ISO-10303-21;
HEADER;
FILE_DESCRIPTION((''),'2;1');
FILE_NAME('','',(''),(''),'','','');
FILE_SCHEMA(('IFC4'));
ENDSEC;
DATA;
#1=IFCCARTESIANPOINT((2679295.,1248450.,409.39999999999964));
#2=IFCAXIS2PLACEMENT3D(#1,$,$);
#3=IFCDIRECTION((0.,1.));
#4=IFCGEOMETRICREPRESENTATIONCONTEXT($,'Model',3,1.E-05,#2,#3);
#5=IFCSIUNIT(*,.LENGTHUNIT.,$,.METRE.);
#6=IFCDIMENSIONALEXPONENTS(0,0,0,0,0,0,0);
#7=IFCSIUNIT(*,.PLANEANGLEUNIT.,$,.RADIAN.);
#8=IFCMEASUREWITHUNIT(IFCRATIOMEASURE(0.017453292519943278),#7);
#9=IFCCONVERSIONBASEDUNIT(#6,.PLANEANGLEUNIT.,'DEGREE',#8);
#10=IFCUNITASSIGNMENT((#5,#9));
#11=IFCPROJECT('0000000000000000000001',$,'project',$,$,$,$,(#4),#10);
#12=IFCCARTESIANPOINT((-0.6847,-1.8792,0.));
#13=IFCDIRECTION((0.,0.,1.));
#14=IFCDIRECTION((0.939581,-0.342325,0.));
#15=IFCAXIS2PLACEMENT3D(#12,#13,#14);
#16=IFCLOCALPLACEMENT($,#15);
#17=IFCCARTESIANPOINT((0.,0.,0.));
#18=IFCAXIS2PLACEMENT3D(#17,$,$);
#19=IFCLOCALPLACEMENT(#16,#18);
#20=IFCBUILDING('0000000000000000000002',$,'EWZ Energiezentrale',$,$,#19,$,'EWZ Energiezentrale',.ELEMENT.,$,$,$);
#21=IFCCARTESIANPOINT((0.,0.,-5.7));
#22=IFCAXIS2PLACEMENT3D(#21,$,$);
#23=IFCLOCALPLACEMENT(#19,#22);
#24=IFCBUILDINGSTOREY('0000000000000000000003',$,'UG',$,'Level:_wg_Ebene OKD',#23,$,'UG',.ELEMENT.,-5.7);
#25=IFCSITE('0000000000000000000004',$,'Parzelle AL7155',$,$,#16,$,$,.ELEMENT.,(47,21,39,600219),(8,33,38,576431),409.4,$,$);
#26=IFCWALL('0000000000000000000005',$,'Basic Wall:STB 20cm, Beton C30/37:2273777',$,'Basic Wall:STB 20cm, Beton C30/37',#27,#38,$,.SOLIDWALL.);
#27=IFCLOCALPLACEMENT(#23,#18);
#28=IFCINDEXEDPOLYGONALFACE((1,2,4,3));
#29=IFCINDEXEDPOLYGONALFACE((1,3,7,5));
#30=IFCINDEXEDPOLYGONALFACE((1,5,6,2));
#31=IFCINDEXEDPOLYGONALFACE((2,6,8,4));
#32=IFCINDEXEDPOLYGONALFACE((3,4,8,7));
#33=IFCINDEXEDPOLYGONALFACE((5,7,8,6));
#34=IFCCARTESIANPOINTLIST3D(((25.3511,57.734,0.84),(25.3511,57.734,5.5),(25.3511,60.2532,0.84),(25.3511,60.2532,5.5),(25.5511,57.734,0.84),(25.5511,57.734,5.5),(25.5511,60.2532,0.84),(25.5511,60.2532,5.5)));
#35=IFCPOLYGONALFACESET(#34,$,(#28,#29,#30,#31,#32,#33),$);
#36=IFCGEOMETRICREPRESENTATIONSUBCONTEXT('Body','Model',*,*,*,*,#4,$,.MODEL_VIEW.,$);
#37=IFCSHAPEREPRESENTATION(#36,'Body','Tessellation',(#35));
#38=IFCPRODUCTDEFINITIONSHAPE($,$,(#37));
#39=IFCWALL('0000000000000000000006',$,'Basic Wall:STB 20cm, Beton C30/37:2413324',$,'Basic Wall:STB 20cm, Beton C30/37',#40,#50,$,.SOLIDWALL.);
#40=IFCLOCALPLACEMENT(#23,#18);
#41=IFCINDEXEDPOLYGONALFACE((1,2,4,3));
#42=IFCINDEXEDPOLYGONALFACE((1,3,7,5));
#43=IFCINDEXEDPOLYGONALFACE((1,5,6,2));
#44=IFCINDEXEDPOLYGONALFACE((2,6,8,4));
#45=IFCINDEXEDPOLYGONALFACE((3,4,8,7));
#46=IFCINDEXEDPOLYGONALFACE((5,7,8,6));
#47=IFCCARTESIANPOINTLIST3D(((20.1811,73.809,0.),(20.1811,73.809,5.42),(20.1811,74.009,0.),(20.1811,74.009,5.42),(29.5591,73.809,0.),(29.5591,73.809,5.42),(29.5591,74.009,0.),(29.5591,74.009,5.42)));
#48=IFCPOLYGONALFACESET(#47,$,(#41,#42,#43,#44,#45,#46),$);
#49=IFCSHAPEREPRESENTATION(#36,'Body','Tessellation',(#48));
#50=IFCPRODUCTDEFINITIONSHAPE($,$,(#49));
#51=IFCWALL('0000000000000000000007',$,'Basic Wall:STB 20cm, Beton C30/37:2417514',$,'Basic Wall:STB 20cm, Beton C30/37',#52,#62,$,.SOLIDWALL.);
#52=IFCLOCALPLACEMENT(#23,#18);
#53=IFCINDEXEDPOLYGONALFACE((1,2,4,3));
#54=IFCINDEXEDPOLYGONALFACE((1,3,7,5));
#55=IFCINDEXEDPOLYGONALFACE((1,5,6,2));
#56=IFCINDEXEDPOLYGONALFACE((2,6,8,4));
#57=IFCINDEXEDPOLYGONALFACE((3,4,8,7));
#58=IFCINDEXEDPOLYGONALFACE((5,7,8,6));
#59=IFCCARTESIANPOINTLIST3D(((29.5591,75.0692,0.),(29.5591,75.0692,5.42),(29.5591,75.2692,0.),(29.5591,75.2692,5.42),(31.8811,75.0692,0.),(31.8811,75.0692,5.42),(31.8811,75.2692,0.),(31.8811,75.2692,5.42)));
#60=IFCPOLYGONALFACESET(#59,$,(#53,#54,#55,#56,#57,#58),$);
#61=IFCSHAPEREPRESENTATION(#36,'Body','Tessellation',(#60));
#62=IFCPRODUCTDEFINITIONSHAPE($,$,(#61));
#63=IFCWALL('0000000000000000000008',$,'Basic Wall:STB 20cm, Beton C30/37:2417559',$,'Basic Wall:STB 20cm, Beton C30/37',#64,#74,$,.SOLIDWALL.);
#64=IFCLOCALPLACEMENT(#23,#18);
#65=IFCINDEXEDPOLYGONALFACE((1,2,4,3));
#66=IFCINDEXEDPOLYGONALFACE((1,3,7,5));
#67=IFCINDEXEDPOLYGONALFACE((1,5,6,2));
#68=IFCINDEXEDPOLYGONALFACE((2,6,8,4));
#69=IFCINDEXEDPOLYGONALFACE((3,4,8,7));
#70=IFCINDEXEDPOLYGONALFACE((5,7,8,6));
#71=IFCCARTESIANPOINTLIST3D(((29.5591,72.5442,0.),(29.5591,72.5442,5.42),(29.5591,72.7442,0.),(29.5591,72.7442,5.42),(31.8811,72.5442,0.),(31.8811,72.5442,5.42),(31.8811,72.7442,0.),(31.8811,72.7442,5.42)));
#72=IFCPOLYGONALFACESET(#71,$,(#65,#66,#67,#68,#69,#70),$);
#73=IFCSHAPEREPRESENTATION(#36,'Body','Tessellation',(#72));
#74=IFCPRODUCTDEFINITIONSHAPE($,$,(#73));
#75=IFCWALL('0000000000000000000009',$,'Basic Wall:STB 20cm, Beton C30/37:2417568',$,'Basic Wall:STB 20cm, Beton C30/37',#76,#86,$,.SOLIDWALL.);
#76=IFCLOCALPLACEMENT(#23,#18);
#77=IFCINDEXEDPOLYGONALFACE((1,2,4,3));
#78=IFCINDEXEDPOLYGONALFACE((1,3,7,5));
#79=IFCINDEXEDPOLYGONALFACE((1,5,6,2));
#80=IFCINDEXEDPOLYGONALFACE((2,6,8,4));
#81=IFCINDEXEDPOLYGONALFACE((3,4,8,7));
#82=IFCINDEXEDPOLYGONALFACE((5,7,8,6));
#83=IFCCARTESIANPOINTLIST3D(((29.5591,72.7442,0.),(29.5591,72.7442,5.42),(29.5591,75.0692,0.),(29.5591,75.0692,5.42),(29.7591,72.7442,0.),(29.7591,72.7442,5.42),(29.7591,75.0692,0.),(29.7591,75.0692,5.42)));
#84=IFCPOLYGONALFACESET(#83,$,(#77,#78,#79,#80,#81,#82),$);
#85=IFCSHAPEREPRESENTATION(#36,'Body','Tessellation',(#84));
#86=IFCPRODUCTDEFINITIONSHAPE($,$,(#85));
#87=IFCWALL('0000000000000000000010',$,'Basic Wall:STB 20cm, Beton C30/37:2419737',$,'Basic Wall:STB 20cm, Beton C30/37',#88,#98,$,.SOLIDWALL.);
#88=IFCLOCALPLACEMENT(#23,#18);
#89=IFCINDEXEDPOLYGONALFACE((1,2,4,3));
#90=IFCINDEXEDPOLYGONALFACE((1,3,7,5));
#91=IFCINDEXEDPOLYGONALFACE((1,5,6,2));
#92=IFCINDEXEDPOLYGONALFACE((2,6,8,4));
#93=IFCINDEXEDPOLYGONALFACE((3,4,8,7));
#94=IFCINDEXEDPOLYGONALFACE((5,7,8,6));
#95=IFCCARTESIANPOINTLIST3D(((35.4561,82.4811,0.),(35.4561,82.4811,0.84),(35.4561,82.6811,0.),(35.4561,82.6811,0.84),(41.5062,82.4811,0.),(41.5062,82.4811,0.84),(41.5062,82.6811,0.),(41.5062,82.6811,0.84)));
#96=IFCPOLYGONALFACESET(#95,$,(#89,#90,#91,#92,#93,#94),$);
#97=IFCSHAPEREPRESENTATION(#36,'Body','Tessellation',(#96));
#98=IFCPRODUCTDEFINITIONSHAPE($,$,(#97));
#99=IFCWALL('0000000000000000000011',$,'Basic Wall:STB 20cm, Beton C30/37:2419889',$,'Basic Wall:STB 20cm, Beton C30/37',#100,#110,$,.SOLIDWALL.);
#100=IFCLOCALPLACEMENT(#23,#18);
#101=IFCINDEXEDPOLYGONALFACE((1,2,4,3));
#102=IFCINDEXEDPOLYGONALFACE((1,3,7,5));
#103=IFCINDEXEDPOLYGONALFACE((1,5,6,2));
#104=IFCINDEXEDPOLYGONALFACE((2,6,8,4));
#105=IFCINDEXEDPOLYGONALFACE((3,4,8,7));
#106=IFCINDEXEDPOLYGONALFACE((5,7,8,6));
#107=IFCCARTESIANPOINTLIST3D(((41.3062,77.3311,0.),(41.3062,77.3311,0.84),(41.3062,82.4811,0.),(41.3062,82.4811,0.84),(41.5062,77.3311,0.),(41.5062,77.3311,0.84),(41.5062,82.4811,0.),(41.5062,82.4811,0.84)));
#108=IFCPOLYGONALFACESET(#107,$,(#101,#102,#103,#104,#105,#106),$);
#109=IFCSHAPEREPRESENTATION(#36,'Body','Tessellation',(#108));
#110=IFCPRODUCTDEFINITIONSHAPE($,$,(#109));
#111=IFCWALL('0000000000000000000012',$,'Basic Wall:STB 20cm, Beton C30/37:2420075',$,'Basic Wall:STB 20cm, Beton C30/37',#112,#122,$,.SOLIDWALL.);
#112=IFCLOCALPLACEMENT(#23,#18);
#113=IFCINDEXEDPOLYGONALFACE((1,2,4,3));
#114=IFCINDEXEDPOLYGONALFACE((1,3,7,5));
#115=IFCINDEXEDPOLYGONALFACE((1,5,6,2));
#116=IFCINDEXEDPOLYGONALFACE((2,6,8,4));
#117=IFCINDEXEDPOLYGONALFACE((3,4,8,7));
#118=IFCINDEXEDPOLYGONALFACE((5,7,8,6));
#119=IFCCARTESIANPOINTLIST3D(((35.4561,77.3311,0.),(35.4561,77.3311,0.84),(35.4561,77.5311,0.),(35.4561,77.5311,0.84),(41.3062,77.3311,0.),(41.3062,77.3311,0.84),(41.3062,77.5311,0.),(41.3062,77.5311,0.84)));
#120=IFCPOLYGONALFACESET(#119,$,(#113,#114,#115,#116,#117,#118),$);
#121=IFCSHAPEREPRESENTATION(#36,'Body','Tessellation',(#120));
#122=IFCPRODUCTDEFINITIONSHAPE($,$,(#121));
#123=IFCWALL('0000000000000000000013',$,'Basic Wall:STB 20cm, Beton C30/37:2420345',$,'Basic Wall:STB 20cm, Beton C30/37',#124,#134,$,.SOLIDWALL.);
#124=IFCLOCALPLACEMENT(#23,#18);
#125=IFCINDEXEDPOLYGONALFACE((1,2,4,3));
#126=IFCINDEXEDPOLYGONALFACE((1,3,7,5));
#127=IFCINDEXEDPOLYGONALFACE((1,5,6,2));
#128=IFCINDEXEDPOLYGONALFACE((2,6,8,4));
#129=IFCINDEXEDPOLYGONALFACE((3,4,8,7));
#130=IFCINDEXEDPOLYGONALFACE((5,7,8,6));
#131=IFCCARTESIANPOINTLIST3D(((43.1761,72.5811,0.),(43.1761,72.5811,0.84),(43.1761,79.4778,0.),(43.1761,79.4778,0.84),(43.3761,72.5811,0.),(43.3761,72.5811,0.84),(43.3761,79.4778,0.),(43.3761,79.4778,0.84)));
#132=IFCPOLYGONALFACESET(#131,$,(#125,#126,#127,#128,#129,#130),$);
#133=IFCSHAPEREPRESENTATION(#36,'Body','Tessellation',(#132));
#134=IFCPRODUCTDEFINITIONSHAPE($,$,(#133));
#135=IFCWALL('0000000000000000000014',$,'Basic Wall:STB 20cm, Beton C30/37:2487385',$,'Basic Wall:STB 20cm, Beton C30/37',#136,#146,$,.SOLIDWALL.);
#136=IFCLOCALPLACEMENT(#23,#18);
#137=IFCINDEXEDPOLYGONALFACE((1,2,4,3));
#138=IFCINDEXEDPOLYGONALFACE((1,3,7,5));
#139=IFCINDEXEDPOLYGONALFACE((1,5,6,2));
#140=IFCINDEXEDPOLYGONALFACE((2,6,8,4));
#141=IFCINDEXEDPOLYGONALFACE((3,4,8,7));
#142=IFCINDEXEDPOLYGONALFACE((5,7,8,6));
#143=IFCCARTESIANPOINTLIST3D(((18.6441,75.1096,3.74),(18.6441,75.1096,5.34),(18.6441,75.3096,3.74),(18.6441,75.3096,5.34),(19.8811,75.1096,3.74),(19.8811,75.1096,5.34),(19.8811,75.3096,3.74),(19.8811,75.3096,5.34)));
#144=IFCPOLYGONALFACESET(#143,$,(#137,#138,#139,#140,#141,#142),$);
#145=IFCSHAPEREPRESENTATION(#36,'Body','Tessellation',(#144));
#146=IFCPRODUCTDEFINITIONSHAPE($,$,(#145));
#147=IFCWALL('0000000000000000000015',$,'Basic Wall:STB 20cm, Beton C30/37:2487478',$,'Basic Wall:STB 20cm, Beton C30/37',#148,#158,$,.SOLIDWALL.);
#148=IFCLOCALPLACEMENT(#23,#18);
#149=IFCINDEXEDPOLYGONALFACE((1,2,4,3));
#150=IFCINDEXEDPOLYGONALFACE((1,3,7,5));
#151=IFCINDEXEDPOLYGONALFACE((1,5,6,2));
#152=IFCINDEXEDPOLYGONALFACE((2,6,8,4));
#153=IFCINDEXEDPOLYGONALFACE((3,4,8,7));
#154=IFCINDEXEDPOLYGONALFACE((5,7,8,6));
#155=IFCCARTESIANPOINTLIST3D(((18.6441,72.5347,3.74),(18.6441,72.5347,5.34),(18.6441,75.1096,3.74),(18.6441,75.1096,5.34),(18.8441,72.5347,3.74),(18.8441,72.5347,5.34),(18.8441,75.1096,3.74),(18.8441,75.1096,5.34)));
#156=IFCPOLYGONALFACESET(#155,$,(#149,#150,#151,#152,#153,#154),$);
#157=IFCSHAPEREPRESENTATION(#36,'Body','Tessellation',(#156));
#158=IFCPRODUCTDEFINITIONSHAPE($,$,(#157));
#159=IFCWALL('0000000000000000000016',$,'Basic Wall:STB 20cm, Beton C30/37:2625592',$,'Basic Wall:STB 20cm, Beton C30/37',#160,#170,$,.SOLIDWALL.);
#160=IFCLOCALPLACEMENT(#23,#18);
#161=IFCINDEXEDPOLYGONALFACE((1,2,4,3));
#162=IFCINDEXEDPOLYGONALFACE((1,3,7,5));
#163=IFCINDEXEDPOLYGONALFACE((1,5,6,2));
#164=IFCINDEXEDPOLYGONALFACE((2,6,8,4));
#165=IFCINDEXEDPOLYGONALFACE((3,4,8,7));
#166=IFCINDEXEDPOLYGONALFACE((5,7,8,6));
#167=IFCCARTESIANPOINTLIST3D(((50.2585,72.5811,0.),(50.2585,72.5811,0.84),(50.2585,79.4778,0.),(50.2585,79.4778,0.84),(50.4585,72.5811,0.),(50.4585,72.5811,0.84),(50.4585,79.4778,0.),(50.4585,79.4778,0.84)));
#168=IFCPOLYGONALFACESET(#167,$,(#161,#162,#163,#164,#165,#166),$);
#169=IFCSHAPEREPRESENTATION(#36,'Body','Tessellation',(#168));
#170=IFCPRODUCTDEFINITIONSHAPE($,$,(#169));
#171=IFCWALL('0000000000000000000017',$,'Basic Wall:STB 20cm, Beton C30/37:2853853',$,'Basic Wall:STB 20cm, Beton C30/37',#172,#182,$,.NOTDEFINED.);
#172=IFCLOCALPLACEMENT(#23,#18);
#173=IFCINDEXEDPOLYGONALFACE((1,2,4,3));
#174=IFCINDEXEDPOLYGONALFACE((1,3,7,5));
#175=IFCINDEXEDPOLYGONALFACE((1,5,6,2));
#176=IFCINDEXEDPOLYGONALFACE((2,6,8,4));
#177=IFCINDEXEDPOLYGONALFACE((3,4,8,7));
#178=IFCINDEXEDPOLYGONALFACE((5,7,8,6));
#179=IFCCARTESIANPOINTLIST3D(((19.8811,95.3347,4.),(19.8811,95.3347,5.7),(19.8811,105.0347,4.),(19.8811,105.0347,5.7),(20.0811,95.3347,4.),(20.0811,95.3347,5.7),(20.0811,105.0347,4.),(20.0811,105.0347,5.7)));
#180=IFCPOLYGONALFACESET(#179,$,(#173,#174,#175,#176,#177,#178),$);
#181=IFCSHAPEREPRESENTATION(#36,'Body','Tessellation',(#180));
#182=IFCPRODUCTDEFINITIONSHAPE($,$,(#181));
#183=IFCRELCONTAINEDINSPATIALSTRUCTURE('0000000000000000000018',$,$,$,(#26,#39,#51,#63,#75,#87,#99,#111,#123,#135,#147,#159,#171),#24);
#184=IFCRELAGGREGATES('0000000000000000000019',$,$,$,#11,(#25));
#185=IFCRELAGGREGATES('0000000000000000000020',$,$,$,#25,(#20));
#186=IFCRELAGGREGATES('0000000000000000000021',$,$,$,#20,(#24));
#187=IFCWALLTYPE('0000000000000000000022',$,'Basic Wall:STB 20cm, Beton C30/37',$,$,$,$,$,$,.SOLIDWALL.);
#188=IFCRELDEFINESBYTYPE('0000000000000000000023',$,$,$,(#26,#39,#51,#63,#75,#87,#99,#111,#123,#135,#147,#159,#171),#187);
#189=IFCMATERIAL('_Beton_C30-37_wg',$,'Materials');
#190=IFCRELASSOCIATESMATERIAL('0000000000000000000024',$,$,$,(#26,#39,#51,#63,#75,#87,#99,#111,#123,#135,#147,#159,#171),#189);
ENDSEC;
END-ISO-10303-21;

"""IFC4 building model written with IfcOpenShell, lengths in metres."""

from ifc_helpers import new_model, entity, si_unit, converted_unit, direction, frame, origin, place, context, subcontext, project, spatial, indexed_curve, outline, extrude, material, type_object, element, save


model = new_model("IFC4")

# Units and contexts
model_context = context("Model", 3, precision=1e-05, world=frame((2679295.0, 1248450.0, 409.39999999999964)), true_north=direction((0.0, 1.0)))
body_context = subcontext(model_context, "Body", "Model", "MODEL_VIEW")
ifc_project = project(units=[si_unit("LENGTHUNIT", "METRE"), converted_unit("PLANEANGLEUNIT", "DEGREE", entity("IfcRatioMeasure", 0.017453292519943278), si_unit("PLANEANGLEUNIT", "RADIAN"), dimensions=[0, 0, 0, 0, 0, 0, 0])], contexts=[model_context])

# Site, building, storey
site_placement = place(None, frame((-0.6847, -1.8792, 0.0), z_axis=(0.0, 0.0, 1.0), x_axis=(0.939581, -0.342325, 0.0)))
site = spatial("IfcSite", under=ifc_project, at=site_placement, Name="Parzelle AL7155", CompositionType="ELEMENT", RefLatitude=(47, 21, 39, 600219), RefLongitude=(8, 33, 38, 576431), RefElevation=409.4)
building_placement = place(site_placement, origin())
building = spatial("IfcBuilding", under=site, at=building_placement, Name="EWZ Energiezentrale", LongName="EWZ Energiezentrale", CompositionType="ELEMENT")
storey_placement = place(building_placement, frame((0.0, 0.0, -5.7)))
storey = spatial("IfcBuildingStorey", under=building, at=storey_placement, Name="UG", ObjectType="Level:_wg_Ebene OKD", LongName="UG", CompositionType="ELEMENT", Elevation=-5.7)

# Shared definitions
ifc_material_1 = material(Name="_Beton_C30-37_wg", Category="Materials")

# Walls
wall_type_1 = type_object("IfcWallType", Name="Basic Wall:STB 20cm, Beton C30/37", PredefinedType="SOLIDWALL")
wall_1_placement = place(storey_placement, frame((25.4511, 57.734, 0.84), z_axis=(0.0, 0.0, 1.0), x_axis=(0.0, 1.0, 0.0)))
element("IfcWall", 1, at=wall_1_placement, inside=storey, type_object=wall_type_1, material=ifc_material_1, Name="Basic Wall:STB 20cm, Beton C30/37:2273777", ObjectType="Basic Wall:STB 20cm, Beton C30/37", PredefinedType="SOLIDWALL", context=body_context, shape_type="SweptSolid", body=[
    extrude(outline(indexed_curve([(2.5192, 0.1), (0.0, 0.1), (0.0, -0.1), (2.5192, -0.1), (2.5192, 0.1)], self_intersect=False)), origin(), (0.0, 0.0, 1.0), 4.66),
])
wall_2_placement = place(storey_placement, frame((20.1811, 73.909, 0.0)))
element("IfcWall", 2, at=wall_2_placement, inside=storey, type_object=wall_type_1, material=ifc_material_1, Name="Basic Wall:STB 20cm, Beton C30/37:2413324", ObjectType="Basic Wall:STB 20cm, Beton C30/37", PredefinedType="SOLIDWALL", context=body_context, shape_type="SweptSolid", body=[
    extrude(outline(indexed_curve([(9.378, 0.1), (0.0, 0.1), (0.0, -0.1), (9.378, -0.1), (9.378, 0.1)], self_intersect=False)), origin(), (0.0, 0.0, 1.0), 5.42),
])
for number, where, name in (
    (3, (29.5591, 75.1692, 0.0), "Basic Wall:STB 20cm, Beton C30/37:2417514"),
    (4, (29.5591, 72.6442, 0.0), "Basic Wall:STB 20cm, Beton C30/37:2417559"),
):
    element("IfcWall", number, at=place(storey_placement, frame(where)), inside=storey, type_object=wall_type_1, material=ifc_material_1, Name=name, ObjectType="Basic Wall:STB 20cm, Beton C30/37", PredefinedType="SOLIDWALL", context=body_context, shape_type="SweptSolid", body=[
        extrude(outline(indexed_curve([(2.322, 0.1), (0.0, 0.1), (0.0, -0.1), (2.322, -0.1), (2.322, 0.1)], self_intersect=False)), origin(), (0.0, 0.0, 1.0), 5.42),
    ])
wall_3_placement = place(storey_placement, frame((29.6591, 72.7442, 0.0), z_axis=(0.0, 0.0, 1.0), x_axis=(0.0, 1.0, 0.0)))
element("IfcWall", 5, at=wall_3_placement, inside=storey, type_object=wall_type_1, material=ifc_material_1, Name="Basic Wall:STB 20cm, Beton C30/37:2417568", ObjectType="Basic Wall:STB 20cm, Beton C30/37", PredefinedType="SOLIDWALL", context=body_context, shape_type="SweptSolid", body=[
    extrude(outline(indexed_curve([(2.325, 0.1), (0.0, 0.1), (0.0, -0.1), (2.325, -0.1), (2.325, 0.1)], self_intersect=False)), origin(), (0.0, 0.0, 1.0), 5.42),
])
wall_4_placement = place(storey_placement, frame((35.4561, 82.5811, 0.0)))
element("IfcWall", 6, at=wall_4_placement, inside=storey, type_object=wall_type_1, material=ifc_material_1, Name="Basic Wall:STB 20cm, Beton C30/37:2419737", ObjectType="Basic Wall:STB 20cm, Beton C30/37", PredefinedType="SOLIDWALL", context=body_context, shape_type="SweptSolid", body=[
    extrude(outline(indexed_curve([(6.0502, 0.1), (0.0, 0.1), (0.0, -0.1), (6.0502, -0.1), (6.0502, 0.1)], self_intersect=False)), origin(), (0.0, 0.0, 1.0), 0.84),
])
wall_5_placement = place(storey_placement, frame((41.4062, 82.4811, 0.0), z_axis=(0.0, 0.0, 1.0), x_axis=(0.0, -1.0, 0.0)))
element("IfcWall", 7, at=wall_5_placement, inside=storey, type_object=wall_type_1, material=ifc_material_1, Name="Basic Wall:STB 20cm, Beton C30/37:2419889", ObjectType="Basic Wall:STB 20cm, Beton C30/37", PredefinedType="SOLIDWALL", context=body_context, shape_type="SweptSolid", body=[
    extrude(outline(indexed_curve([(5.15, 0.1), (0.0, 0.1), (0.0, -0.1), (5.15, -0.1), (5.15, 0.1)], self_intersect=False)), origin(), (0.0, 0.0, 1.0), 0.84),
])
wall_6_placement = place(storey_placement, frame((41.3062, 77.4311, 0.0), z_axis=(0.0, 0.0, 1.0), x_axis=(-1.0, 0.0, 0.0)))
element("IfcWall", 8, at=wall_6_placement, inside=storey, type_object=wall_type_1, material=ifc_material_1, Name="Basic Wall:STB 20cm, Beton C30/37:2420075", ObjectType="Basic Wall:STB 20cm, Beton C30/37", PredefinedType="SOLIDWALL", context=body_context, shape_type="SweptSolid", body=[
    extrude(outline(indexed_curve([(5.8502, 0.1), (0.0, 0.1), (0.0, -0.1), (5.8502, -0.1), (5.8502, 0.1)], self_intersect=False)), origin(), (0.0, 0.0, 1.0), 0.84),
])
wall_7_placement = place(storey_placement, frame((43.2761, 72.5811, 0.0), z_axis=(0.0, 0.0, 1.0), x_axis=(0.0, 1.0, 0.0)))
element("IfcWall", 9, at=wall_7_placement, inside=storey, type_object=wall_type_1, material=ifc_material_1, Name="Basic Wall:STB 20cm, Beton C30/37:2420345", ObjectType="Basic Wall:STB 20cm, Beton C30/37", PredefinedType="SOLIDWALL", context=body_context, shape_type="SweptSolid", body=[
    extrude(outline(indexed_curve([(6.8967, 0.1), (0.0, 0.1), (0.0, -0.1), (6.8967, -0.1), (6.8967, 0.1)], self_intersect=False)), origin(), (0.0, 0.0, 1.0), 0.84),
])
wall_8_placement = place(storey_placement, frame((19.8811, 75.2096, 3.74), z_axis=(0.0, 0.0, 1.0), x_axis=(-1.0, 0.0, 0.0)))
element("IfcWall", 10, at=wall_8_placement, inside=storey, type_object=wall_type_1, material=ifc_material_1, Name="Basic Wall:STB 20cm, Beton C30/37:2487385", ObjectType="Basic Wall:STB 20cm, Beton C30/37", PredefinedType="SOLIDWALL", context=body_context, shape_type="SweptSolid", body=[
    extrude(outline(indexed_curve([(1.237, 0.1), (0.0, 0.1), (0.0, -0.1), (1.237, -0.1), (1.237, 0.1)], self_intersect=False)), origin(), (0.0, 0.0, 1.0), 1.6),
])
wall_9_placement = place(storey_placement, frame((18.7441, 75.1096, 3.74), z_axis=(0.0, 0.0, 1.0), x_axis=(0.0, -1.0, 0.0)))
element("IfcWall", 11, at=wall_9_placement, inside=storey, type_object=wall_type_1, material=ifc_material_1, Name="Basic Wall:STB 20cm, Beton C30/37:2487478", ObjectType="Basic Wall:STB 20cm, Beton C30/37", PredefinedType="SOLIDWALL", context=body_context, shape_type="SweptSolid", body=[
    extrude(outline(indexed_curve([(2.5749, 0.1), (0.0, 0.1), (0.0, -0.1), (2.5749, -0.1), (2.5749, 0.1)], self_intersect=False)), origin(), (0.0, 0.0, 1.0), 1.6),
])
wall_10_placement = place(storey_placement, frame((50.3585, 79.4778, 0.0), z_axis=(0.0, 0.0, 1.0), x_axis=(0.0, -1.0, 0.0)))
element("IfcWall", 12, at=wall_10_placement, inside=storey, type_object=wall_type_1, material=ifc_material_1, Name="Basic Wall:STB 20cm, Beton C30/37:2625592", ObjectType="Basic Wall:STB 20cm, Beton C30/37", PredefinedType="SOLIDWALL", context=body_context, shape_type="SweptSolid", body=[
    extrude(outline(indexed_curve([(6.8967, 0.1), (0.0, 0.1), (0.0, -0.1), (6.8967, -0.1), (6.8967, 0.1)], self_intersect=False)), origin(), (0.0, 0.0, 1.0), 0.84),
])
wall_11_placement = place(storey_placement, frame((19.9811, 95.3347, 4.0), z_axis=(0.0, 0.0, 1.0), x_axis=(0.0, 1.0, 0.0)))
element("IfcWall", 13, at=wall_11_placement, inside=storey, type_object=wall_type_1, material=ifc_material_1, Name="Basic Wall:STB 20cm, Beton C30/37:2853853", ObjectType="Basic Wall:STB 20cm, Beton C30/37", PredefinedType="NOTDEFINED", context=body_context, shape_type="SweptSolid", body=[
    extrude(outline(indexed_curve([(9.7, 0.1), (0.0, 0.1), (0.0, -0.1), (9.7, -0.1), (9.7, 0.1)], self_intersect=False)), origin(), (0.0, 0.0, 1.0), 1.7),
])

save(model, "model.ifc")
